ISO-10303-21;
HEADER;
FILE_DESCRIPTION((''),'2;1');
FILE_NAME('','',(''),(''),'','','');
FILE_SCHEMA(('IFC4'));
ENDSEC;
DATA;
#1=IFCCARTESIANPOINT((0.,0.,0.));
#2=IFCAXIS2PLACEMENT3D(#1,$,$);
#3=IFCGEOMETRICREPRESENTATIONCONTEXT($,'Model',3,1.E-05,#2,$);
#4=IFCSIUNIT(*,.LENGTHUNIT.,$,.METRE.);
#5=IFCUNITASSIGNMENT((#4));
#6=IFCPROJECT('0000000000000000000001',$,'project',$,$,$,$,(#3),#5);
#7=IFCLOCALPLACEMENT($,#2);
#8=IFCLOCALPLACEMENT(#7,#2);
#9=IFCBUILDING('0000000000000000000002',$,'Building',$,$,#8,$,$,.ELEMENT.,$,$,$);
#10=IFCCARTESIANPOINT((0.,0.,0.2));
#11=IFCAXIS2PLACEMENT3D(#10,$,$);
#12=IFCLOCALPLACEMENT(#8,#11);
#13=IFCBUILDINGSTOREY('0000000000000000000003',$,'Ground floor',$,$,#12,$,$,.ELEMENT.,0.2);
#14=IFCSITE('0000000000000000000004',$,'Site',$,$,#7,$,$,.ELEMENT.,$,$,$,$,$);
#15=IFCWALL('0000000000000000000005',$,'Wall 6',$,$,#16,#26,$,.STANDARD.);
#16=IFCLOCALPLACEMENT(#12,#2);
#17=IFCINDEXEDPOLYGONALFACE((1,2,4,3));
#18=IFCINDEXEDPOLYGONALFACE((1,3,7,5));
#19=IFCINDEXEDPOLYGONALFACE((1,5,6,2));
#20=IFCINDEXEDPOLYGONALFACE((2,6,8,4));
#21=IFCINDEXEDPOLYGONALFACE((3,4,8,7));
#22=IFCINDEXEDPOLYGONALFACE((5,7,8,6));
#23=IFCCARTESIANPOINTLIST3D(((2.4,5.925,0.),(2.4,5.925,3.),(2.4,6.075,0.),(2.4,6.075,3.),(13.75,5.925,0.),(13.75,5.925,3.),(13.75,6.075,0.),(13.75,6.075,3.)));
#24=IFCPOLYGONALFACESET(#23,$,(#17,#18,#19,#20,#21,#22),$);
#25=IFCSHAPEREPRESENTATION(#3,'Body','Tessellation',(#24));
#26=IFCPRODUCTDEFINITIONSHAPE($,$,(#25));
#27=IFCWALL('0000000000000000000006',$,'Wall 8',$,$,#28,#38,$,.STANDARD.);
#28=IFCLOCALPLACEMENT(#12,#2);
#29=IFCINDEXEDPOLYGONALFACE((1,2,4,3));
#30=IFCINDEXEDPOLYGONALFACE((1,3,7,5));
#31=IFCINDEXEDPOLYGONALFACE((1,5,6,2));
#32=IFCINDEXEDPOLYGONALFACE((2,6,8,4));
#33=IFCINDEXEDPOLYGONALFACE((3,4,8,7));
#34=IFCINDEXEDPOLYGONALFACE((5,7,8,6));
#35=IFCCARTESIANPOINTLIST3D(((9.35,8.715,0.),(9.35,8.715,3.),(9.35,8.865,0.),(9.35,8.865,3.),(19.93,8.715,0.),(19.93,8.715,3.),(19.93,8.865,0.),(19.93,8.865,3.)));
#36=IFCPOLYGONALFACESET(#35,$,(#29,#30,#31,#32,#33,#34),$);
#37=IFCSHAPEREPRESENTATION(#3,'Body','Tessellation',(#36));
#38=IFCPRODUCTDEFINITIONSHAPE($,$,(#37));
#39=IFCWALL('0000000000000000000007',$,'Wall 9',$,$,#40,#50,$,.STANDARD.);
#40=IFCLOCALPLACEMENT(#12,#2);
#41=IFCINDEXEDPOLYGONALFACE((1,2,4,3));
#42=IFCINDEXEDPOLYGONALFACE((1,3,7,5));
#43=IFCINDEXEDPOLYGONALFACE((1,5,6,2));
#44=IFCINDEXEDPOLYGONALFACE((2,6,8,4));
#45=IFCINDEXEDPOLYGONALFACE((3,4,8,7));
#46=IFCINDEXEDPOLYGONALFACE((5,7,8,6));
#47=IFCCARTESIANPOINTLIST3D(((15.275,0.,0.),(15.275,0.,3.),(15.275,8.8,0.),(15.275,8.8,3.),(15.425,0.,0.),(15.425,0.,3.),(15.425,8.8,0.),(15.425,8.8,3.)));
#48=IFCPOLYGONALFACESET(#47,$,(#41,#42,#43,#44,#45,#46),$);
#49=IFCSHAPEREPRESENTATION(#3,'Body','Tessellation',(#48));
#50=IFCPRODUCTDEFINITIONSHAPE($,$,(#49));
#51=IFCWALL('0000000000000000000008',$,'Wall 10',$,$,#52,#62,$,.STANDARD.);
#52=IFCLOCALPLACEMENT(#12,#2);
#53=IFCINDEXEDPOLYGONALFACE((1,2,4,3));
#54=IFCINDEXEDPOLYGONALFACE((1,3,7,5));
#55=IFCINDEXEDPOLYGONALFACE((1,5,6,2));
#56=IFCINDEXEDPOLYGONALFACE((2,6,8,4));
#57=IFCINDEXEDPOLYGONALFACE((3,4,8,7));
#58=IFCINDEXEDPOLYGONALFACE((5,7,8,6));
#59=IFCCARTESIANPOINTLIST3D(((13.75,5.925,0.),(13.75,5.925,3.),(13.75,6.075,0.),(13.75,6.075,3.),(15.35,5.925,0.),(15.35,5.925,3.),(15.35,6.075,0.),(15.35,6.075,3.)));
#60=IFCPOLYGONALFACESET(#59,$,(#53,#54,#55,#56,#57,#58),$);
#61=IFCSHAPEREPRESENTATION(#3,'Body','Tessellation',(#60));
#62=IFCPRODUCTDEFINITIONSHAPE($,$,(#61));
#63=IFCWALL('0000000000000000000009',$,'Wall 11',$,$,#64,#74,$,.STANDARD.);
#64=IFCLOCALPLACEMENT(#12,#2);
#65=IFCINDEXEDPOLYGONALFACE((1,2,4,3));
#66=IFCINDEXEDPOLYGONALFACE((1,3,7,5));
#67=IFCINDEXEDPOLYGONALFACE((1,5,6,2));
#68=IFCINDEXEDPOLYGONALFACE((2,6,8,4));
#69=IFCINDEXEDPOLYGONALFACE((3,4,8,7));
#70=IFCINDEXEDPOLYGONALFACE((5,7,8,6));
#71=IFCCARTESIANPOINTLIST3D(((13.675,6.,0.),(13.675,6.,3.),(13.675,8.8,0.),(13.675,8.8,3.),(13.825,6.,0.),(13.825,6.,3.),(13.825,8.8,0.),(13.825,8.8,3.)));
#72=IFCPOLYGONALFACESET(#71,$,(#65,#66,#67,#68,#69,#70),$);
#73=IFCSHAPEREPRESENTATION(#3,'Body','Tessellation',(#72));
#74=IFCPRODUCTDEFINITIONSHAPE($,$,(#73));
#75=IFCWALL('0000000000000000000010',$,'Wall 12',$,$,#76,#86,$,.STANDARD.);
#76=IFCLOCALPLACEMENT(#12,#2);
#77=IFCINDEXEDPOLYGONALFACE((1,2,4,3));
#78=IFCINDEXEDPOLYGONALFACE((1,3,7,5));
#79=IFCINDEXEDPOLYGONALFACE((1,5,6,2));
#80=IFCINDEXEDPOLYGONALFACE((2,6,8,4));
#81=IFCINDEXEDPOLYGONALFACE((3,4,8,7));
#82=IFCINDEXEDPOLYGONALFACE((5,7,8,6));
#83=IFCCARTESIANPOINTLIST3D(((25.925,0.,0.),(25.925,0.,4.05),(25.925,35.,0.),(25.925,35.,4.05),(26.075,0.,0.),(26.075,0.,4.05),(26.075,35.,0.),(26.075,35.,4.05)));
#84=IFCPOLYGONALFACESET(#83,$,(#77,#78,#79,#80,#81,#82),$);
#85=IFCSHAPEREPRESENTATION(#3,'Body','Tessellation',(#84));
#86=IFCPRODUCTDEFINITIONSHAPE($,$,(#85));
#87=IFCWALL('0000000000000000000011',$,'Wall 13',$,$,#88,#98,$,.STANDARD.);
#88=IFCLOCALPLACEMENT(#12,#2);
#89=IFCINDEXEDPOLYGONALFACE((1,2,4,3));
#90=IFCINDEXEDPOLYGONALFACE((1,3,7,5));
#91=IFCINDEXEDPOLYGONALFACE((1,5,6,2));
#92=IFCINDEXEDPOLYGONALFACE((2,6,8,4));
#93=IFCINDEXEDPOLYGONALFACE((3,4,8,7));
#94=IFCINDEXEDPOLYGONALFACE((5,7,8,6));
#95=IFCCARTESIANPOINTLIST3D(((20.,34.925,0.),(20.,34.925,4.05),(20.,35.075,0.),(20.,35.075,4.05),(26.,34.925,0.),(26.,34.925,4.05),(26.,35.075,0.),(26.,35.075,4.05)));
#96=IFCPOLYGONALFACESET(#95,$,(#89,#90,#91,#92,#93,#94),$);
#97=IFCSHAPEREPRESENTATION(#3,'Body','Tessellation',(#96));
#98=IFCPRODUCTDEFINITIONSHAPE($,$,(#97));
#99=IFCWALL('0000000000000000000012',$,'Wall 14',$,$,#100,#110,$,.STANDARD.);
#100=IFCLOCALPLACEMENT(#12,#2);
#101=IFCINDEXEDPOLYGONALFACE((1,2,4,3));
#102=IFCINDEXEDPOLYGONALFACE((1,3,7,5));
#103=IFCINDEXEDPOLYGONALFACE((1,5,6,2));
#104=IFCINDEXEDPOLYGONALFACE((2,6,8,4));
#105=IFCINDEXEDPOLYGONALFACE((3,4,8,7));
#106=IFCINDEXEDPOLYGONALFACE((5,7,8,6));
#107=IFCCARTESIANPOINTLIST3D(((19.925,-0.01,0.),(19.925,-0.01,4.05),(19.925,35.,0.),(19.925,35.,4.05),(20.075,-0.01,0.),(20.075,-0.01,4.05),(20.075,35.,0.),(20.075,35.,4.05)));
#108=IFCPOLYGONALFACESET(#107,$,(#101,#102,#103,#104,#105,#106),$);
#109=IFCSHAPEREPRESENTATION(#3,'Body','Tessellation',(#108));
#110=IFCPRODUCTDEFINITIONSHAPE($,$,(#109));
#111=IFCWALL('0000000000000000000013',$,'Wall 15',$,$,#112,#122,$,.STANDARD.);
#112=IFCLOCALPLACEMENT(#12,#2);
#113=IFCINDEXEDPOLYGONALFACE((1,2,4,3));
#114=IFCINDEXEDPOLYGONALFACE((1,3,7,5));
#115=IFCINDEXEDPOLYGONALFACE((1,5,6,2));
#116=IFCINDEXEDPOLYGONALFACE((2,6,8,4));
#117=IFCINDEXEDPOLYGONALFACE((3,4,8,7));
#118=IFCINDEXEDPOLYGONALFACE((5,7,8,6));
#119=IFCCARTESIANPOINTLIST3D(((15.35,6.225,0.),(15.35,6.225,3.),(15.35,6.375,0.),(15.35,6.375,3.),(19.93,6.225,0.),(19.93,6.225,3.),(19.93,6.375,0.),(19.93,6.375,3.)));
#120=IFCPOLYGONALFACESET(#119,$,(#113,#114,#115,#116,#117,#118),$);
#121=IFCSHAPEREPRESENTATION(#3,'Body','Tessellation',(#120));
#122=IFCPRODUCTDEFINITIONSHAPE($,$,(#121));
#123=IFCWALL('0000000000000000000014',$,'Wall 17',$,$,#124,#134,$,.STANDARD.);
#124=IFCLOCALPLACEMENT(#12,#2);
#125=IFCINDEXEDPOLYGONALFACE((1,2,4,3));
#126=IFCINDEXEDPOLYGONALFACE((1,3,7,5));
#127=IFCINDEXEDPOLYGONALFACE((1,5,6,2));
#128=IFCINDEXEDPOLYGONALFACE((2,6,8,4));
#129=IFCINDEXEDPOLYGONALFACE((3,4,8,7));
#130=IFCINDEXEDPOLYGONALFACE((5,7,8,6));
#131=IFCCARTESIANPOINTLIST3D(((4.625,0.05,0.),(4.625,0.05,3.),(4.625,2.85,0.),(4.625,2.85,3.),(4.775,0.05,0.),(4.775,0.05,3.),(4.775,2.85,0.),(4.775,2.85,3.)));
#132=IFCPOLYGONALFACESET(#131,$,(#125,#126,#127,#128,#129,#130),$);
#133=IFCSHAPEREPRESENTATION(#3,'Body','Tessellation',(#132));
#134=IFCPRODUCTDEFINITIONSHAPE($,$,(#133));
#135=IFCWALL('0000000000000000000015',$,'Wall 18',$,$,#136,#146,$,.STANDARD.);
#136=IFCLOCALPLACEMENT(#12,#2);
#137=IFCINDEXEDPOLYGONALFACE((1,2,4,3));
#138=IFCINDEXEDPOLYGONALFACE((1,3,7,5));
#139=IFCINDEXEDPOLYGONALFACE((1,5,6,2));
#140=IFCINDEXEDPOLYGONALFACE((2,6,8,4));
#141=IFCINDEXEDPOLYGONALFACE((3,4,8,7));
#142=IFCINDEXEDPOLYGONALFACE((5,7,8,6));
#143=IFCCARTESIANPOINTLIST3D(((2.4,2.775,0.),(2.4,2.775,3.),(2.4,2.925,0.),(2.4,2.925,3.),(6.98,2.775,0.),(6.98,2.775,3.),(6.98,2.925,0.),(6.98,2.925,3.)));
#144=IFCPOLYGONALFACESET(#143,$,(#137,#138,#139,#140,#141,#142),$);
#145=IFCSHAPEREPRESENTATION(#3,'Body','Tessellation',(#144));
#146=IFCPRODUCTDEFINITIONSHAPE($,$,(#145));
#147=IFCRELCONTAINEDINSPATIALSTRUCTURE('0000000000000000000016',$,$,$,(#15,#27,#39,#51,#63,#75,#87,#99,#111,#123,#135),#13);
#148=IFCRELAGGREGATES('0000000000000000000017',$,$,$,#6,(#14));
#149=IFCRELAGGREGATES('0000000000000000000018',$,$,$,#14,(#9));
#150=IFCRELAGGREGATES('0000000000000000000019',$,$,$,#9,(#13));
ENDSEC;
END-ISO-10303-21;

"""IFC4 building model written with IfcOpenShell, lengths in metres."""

from ifc_helpers import new_model, si_unit, frame, frame_2d, origin, place, context, project, spatial, rectangle, extrude, element, save


model = new_model("IFC4")

# Units and contexts
model_context = context("Model", 3, precision=1e-05, world=origin())
ifc_project = project(units=[si_unit("LENGTHUNIT", "METRE")], contexts=[model_context])

# Site, building, storey
site_placement = place(None, origin())
site = spatial("IfcSite", under=ifc_project, at=site_placement, Name="Site", CompositionType="ELEMENT")
building_placement = place(site_placement, origin())
building = spatial("IfcBuilding", under=site, at=building_placement, Name="Building", CompositionType="ELEMENT")
storey_placement = place(building_placement, frame((0.0, 0.0, 0.2)))
storey = spatial("IfcBuildingStorey", under=building, at=storey_placement, Name="Ground floor", CompositionType="ELEMENT", Elevation=0.2)

# Walls
wall_1_placement = place(storey_placement, frame((2.4, 6.0, 0.0), z_axis=(0.0, 0.0, 1.0), x_axis=(1.0, 0.0, 0.0)))
element("IfcWall", 1, at=wall_1_placement, inside=storey, Name="Wall 6", PredefinedType="STANDARD", context=model_context, shape_type="SweptSolid", body=[
    extrude(rectangle(XDim=11.35, YDim=0.15, at=frame_2d((5.675, 0.0))), origin(), (0.0, 0.0, 1.0), 3.0),
])
wall_2_placement = place(storey_placement, frame((9.35, 8.79, 0.0), z_axis=(0.0, 0.0, 1.0), x_axis=(1.0, 0.0, 0.0)))
element("IfcWall", 2, at=wall_2_placement, inside=storey, Name="Wall 8", PredefinedType="STANDARD", context=model_context, shape_type="SweptSolid", body=[
    extrude(rectangle(XDim=10.58, YDim=0.15, at=frame_2d((5.29, 0.0))), origin(), (0.0, 0.0, 1.0), 3.0),
])
wall_3_placement = place(storey_placement, frame((15.35, 8.8, 0.0), z_axis=(0.0, 0.0, 1.0), x_axis=(0.0, -1.0, 0.0)))
element("IfcWall", 3, at=wall_3_placement, inside=storey, Name="Wall 9", PredefinedType="STANDARD", context=model_context, shape_type="SweptSolid", body=[
    extrude(rectangle(XDim=8.8, YDim=0.15, at=frame_2d((4.4, 0.0))), origin(), (0.0, 0.0, 1.0), 3.0),
])
wall_4_placement = place(storey_placement, frame((15.35, 6.0, 0.0), z_axis=(0.0, 0.0, 1.0), x_axis=(-1.0, 0.0, 0.0)))
element("IfcWall", 4, at=wall_4_placement, inside=storey, Name="Wall 10", PredefinedType="STANDARD", context=model_context, shape_type="SweptSolid", body=[
    extrude(rectangle(XDim=1.6, YDim=0.15, at=frame_2d((0.8, 0.0))), origin(), (0.0, 0.0, 1.0), 3.0),
])
wall_5_placement = place(storey_placement, frame((13.75, 6.0, 0.0), z_axis=(0.0, 0.0, 1.0), x_axis=(0.0, 1.0, 0.0)))
element("IfcWall", 5, at=wall_5_placement, inside=storey, Name="Wall 11", PredefinedType="STANDARD", context=model_context, shape_type="SweptSolid", body=[
    extrude(rectangle(XDim=2.8, YDim=0.15, at=frame_2d((1.4, 0.0))), origin(), (0.0, 0.0, 1.0), 3.0),
])
wall_6_placement = place(storey_placement, frame((26.0, 35.0, 0.0), z_axis=(0.0, 0.0, 1.0), x_axis=(0.0, -1.0, 0.0)))
element("IfcWall", 6, at=wall_6_placement, inside=storey, Name="Wall 12", PredefinedType="STANDARD", context=model_context, shape_type="SweptSolid", body=[
    extrude(rectangle(XDim=35.0, YDim=0.15, at=frame_2d((17.5, 0.0))), origin(), (0.0, 0.0, 1.0), 4.05),
])
wall_7_placement = place(storey_placement, frame((26.0, 35.0, 0.0), z_axis=(0.0, 0.0, 1.0), x_axis=(-1.0, 0.0, 0.0)))
element("IfcWall", 7, at=wall_7_placement, inside=storey, Name="Wall 13", PredefinedType="STANDARD", context=model_context, shape_type="SweptSolid", body=[
    extrude(rectangle(XDim=6.0, YDim=0.15, at=frame_2d((3.0, 0.0))), origin(), (0.0, 0.0, 1.0), 4.05),
])
wall_8_placement = place(storey_placement, frame((20.0, 35.0, 0.0), z_axis=(0.0, 0.0, 1.0), x_axis=(0.0, -1.0, 0.0)))
element("IfcWall", 8, at=wall_8_placement, inside=storey, Name="Wall 14", PredefinedType="STANDARD", context=model_context, shape_type="SweptSolid", body=[
    extrude(rectangle(XDim=35.01, YDim=0.15, at=frame_2d((17.505, 0.0))), origin(), (0.0, 0.0, 1.0), 4.05),
])
wall_9_placement = place(storey_placement, frame((15.35, 6.3, 0.0), z_axis=(0.0, 0.0, 1.0), x_axis=(1.0, 0.0, 0.0)))
element("IfcWall", 9, at=wall_9_placement, inside=storey, Name="Wall 15", PredefinedType="STANDARD", context=model_context, shape_type="SweptSolid", body=[
    extrude(rectangle(XDim=4.58, YDim=0.15, at=frame_2d((2.29, 0.0))), origin(), (0.0, 0.0, 1.0), 3.0),
])
wall_10_placement = place(storey_placement, frame((4.7, 0.05, 0.0), z_axis=(0.0, 0.0, 1.0), x_axis=(0.0, 1.0, 0.0)))
element("IfcWall", 10, at=wall_10_placement, inside=storey, Name="Wall 17", PredefinedType="STANDARD", context=model_context, shape_type="SweptSolid", body=[
    extrude(rectangle(XDim=2.8, YDim=0.15, at=frame_2d((1.4, 0.0))), origin(), (0.0, 0.0, 1.0), 3.0),
])
wall_11_placement = place(storey_placement, frame((2.4, 2.85, 0.0), z_axis=(0.0, 0.0, 1.0), x_axis=(1.0, 0.0, 0.0)))
element("IfcWall", 11, at=wall_11_placement, inside=storey, Name="Wall 18", PredefinedType="STANDARD", context=model_context, shape_type="SweptSolid", body=[
    extrude(rectangle(XDim=4.58, YDim=0.15, at=frame_2d((2.29, 0.0))), origin(), (0.0, 0.0, 1.0), 3.0),
])

save(model, "model.ifc")
